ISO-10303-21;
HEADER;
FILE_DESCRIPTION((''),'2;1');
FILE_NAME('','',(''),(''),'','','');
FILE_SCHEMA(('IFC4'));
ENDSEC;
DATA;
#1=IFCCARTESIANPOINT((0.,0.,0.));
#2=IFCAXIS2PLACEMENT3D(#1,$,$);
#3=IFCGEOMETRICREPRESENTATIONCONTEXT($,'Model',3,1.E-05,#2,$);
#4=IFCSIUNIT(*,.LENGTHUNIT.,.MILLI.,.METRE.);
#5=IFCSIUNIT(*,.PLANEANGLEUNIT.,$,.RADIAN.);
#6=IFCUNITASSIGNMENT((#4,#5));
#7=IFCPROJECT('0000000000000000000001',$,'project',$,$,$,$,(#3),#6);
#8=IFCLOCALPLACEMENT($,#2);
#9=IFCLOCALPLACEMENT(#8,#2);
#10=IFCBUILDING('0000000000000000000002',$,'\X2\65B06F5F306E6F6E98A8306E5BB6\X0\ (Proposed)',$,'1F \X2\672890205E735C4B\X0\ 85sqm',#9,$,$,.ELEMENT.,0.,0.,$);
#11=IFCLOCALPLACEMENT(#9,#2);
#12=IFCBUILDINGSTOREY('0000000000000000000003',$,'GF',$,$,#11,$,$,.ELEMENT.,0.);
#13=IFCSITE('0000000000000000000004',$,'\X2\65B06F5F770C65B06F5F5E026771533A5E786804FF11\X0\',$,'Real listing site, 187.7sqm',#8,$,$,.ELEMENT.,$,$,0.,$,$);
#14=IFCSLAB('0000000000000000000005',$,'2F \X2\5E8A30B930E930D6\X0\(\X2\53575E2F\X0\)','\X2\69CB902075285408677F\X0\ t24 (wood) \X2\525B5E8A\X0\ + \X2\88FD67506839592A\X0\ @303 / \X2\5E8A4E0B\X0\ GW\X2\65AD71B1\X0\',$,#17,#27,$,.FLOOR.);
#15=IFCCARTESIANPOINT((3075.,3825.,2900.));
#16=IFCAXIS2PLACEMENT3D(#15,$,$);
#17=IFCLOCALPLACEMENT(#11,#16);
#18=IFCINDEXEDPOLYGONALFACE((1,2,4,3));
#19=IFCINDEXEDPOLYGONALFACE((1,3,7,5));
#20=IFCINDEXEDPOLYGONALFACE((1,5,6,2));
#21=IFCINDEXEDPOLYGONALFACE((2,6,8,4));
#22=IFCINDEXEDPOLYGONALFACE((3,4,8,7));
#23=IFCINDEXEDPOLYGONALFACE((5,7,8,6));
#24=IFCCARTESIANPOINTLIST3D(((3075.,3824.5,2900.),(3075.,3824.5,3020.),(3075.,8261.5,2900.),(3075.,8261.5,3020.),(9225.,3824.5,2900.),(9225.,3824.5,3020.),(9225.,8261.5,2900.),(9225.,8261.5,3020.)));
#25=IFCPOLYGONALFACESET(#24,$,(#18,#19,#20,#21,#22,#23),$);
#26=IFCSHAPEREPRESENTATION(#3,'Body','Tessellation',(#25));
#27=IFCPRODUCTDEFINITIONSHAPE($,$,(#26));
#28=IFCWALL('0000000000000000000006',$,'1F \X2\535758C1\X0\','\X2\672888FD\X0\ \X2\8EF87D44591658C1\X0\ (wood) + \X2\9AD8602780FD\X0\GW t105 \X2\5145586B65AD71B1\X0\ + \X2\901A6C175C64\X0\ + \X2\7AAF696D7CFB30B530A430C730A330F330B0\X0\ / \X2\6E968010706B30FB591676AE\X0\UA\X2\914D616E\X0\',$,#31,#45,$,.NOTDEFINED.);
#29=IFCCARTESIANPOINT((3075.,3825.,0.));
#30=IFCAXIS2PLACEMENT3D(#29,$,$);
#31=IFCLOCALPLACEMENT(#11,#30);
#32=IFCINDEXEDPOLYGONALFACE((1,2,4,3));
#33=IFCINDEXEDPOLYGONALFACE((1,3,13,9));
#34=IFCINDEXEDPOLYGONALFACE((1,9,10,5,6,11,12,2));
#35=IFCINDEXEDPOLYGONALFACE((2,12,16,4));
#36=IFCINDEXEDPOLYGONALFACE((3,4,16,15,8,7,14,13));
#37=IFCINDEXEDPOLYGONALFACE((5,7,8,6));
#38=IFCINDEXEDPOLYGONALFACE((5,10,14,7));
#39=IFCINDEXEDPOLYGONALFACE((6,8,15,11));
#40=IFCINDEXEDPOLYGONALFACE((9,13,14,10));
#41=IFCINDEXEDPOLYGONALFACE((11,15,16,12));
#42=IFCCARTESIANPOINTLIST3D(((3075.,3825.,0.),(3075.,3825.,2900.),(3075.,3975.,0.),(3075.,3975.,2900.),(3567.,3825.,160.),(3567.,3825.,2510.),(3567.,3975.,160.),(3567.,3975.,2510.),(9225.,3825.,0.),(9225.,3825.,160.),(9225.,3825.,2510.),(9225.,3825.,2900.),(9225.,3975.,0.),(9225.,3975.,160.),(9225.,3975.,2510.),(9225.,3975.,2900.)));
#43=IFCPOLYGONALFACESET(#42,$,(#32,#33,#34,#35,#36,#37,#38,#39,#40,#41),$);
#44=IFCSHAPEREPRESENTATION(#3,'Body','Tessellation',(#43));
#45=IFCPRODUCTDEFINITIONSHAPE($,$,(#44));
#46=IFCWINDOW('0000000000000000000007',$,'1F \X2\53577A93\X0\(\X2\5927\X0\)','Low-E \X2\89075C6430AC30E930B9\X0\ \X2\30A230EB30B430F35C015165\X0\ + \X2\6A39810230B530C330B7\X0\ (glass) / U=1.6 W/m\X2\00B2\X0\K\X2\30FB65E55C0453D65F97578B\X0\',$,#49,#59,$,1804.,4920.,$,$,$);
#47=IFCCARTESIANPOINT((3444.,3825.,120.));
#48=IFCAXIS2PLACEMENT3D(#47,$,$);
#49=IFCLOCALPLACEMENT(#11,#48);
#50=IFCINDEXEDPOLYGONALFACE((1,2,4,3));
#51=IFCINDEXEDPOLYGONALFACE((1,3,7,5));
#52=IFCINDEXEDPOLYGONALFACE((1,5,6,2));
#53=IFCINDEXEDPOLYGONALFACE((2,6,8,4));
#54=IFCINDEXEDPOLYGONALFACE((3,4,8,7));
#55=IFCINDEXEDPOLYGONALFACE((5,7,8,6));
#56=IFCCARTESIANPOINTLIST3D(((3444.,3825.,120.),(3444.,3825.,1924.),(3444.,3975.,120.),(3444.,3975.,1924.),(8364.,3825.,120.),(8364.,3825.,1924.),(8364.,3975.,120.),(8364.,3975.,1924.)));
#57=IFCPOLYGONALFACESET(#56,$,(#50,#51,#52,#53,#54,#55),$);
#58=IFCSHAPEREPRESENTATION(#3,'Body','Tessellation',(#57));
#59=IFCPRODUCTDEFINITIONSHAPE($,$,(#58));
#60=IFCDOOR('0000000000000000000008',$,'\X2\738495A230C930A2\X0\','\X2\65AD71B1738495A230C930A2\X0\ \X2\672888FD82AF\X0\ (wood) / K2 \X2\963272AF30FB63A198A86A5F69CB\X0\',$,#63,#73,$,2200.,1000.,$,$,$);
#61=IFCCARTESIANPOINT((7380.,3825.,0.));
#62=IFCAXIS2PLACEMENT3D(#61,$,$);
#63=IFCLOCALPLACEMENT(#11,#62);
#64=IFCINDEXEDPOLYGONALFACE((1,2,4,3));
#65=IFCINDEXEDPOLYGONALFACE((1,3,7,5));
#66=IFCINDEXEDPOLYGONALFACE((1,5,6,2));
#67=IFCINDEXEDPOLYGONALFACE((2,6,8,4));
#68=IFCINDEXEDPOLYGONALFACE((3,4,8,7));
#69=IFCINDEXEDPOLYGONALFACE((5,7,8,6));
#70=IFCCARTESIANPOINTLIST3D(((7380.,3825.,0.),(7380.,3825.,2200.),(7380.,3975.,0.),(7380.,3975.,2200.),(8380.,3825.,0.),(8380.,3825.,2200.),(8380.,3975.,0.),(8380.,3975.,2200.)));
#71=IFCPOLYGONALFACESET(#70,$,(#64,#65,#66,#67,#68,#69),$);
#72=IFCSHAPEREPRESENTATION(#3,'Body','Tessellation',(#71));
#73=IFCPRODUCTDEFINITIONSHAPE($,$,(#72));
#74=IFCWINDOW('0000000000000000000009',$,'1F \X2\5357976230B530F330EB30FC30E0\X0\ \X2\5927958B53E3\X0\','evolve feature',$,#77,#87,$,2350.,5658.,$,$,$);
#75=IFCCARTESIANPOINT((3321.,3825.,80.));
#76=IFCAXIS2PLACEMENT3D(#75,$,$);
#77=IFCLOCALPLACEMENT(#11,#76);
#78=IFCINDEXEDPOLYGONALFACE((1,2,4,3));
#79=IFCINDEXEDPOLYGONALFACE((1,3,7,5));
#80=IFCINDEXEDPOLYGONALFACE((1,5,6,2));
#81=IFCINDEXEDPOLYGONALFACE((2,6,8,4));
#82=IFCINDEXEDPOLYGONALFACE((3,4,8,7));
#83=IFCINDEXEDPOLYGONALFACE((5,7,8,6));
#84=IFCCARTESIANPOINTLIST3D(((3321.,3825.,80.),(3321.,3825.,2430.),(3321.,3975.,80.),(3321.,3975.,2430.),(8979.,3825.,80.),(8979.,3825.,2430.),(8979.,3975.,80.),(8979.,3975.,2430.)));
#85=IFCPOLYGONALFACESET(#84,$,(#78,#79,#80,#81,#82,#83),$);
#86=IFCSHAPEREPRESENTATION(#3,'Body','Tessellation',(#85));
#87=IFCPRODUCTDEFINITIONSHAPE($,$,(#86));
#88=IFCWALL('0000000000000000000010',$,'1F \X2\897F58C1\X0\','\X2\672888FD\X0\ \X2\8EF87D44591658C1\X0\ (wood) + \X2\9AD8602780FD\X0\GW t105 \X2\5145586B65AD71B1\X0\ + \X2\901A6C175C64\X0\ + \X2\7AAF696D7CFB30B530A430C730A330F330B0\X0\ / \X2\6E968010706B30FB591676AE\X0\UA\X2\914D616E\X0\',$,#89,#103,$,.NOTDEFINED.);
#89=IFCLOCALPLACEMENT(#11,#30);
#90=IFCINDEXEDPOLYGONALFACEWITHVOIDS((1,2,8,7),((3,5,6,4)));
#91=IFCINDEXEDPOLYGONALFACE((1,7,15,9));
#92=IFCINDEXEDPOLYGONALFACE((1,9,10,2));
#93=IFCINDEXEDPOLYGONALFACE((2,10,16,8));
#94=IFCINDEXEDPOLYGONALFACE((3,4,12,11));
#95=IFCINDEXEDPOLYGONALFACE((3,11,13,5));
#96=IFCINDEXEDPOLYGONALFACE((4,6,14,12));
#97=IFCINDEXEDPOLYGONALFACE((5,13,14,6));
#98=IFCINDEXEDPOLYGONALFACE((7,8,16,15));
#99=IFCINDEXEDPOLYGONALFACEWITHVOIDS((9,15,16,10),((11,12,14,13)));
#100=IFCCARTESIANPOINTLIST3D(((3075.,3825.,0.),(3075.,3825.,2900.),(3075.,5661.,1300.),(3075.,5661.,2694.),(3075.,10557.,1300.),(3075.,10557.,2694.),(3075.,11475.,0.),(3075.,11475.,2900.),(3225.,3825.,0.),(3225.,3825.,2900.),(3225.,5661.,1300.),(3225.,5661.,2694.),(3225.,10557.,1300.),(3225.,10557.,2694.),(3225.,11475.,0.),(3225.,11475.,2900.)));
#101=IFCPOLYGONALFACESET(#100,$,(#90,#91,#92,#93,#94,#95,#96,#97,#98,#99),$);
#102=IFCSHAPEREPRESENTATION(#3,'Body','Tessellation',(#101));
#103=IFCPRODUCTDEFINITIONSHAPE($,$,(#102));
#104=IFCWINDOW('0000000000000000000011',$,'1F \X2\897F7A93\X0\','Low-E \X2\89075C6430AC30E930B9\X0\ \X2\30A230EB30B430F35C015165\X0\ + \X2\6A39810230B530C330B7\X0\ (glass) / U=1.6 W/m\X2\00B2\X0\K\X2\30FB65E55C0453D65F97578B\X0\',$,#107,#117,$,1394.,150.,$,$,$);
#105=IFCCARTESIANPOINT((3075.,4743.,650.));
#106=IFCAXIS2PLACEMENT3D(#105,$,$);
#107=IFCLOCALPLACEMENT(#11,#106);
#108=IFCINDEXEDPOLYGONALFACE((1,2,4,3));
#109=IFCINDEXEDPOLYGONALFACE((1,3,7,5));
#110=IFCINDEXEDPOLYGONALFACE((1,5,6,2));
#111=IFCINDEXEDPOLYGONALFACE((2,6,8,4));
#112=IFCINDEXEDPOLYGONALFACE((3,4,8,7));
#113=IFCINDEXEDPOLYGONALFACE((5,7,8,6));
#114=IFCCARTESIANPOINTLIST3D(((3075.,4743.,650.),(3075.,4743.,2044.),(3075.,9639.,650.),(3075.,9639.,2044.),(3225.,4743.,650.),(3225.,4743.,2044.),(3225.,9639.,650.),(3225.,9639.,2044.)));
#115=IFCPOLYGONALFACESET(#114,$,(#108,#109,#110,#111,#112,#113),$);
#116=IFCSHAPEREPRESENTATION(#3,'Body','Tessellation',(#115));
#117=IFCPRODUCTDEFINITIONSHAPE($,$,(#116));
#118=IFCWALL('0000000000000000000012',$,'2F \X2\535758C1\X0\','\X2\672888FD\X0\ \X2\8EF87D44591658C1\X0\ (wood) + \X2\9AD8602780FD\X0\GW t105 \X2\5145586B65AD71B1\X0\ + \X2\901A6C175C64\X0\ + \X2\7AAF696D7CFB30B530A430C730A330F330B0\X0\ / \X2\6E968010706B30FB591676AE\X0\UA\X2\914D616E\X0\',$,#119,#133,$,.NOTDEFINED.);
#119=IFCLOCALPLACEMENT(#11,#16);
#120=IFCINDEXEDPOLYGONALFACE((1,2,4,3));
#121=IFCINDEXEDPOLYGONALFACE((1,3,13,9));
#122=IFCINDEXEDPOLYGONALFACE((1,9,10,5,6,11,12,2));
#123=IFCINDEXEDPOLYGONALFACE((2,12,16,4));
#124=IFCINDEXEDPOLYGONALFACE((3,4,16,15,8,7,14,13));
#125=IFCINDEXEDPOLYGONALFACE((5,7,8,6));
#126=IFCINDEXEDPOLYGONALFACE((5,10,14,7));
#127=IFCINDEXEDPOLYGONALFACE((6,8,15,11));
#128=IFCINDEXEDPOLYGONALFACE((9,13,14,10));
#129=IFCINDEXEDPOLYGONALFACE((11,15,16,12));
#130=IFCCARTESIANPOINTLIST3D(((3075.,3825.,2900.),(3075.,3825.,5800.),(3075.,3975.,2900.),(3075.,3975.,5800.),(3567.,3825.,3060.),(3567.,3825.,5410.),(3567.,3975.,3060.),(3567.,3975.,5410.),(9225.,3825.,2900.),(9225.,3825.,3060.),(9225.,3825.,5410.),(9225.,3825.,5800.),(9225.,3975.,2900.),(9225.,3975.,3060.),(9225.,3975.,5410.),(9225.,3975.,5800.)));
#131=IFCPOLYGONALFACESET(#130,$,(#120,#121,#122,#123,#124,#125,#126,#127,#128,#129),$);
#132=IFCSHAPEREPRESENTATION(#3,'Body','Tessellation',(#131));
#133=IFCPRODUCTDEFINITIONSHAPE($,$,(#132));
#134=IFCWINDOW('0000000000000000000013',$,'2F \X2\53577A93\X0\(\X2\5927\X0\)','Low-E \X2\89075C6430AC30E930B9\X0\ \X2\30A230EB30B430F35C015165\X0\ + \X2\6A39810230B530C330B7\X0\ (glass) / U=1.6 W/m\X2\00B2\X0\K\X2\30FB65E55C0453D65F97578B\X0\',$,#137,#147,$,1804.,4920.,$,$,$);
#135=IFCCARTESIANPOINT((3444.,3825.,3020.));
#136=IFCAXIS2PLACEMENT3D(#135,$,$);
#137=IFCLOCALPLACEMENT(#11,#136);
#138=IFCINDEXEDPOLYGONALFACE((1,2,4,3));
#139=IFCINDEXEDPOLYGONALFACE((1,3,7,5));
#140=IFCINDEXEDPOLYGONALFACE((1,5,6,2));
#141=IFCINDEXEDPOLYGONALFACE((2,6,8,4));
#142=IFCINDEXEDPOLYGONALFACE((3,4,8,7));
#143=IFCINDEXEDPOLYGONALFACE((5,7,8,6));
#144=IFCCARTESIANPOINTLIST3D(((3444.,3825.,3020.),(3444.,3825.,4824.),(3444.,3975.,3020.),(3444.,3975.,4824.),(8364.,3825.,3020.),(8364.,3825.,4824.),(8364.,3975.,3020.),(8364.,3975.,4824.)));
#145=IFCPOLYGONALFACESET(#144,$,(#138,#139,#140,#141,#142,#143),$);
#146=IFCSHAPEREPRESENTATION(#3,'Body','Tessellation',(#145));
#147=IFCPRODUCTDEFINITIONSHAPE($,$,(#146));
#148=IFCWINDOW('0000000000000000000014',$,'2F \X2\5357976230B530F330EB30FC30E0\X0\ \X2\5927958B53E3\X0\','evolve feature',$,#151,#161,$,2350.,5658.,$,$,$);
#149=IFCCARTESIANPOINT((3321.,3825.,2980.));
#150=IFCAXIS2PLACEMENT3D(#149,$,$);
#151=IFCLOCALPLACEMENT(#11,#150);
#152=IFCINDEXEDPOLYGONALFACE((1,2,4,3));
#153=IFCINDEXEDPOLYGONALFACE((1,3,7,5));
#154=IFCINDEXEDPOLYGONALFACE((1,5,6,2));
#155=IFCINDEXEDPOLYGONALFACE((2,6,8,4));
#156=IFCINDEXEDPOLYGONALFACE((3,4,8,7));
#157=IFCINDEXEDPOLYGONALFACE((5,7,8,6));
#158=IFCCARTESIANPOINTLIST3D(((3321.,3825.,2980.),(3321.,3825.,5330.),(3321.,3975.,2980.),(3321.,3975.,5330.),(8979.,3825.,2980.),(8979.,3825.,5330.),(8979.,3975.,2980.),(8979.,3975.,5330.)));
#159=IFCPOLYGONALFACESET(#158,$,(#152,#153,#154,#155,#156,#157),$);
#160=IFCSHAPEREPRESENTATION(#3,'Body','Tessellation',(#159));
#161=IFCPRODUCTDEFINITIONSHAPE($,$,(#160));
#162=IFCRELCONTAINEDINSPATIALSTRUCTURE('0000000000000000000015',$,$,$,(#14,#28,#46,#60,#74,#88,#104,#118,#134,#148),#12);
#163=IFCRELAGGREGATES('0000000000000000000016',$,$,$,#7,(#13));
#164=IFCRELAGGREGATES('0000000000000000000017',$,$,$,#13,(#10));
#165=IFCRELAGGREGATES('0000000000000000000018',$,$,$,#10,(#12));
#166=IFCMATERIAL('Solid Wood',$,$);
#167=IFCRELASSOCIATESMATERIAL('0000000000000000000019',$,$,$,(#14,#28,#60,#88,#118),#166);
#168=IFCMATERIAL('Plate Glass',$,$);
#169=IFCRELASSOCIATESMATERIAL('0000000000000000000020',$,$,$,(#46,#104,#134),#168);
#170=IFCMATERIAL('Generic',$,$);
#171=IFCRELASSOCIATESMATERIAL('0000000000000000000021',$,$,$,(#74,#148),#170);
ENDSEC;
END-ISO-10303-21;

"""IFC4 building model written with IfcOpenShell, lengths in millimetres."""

from ifc_helpers import new_model, si_unit, frame, frame_2d, origin, place, context, project, spatial, rectangle, extrude, material, element, fill, save


model = new_model("IFC4")

# Units and contexts
model_context = context("Model", 3, precision=1e-05, world=origin())
ifc_project = project(units=[si_unit("LENGTHUNIT", "METRE", prefix="MILLI"), si_unit("PLANEANGLEUNIT", "RADIAN")], contexts=[model_context])

# Site, building, storey
site_placement = place(None, origin())
site = spatial("IfcSite", under=ifc_project, at=site_placement, Name="新潟県新潟市東区幸栄１", ObjectType="Real listing site, 187.7sqm", CompositionType="ELEMENT", RefElevation=0.0)
building_placement = place(site_placement, origin())
building = spatial("IfcBuilding", under=site, at=building_placement, Name="新潟の潮風の家 (Proposed)", ObjectType="1F 木造平屋 85sqm", CompositionType="ELEMENT", ElevationOfRefHeight=0.0, ElevationOfTerrain=0.0)
storey_placement = place(building_placement, origin())
storey = spatial("IfcBuildingStorey", under=building, at=storey_placement, Name="GF", CompositionType="ELEMENT", Elevation=0.0)

# Slab
ifc_material_1 = material(Name="Solid Wood")
slab_1_placement = place(storey_placement, frame((3075.0, 3825.0, 2900.0)))
element("IfcSlab", 1, at=slab_1_placement, inside=storey, material=ifc_material_1, Name="2F 床スラブ(南帯)", Description="構造用合板 t24 (wood) 剛床 + 製材根太 @303 / 床下 GW断熱", PredefinedType="FLOOR", context=model_context, shape_type="SweptSolid", body=[
    extrude(rectangle(XDim=6150.0, YDim=4437.0, at=frame_2d((3075.0, 2218.0))), frame((3075.0, 3825.0, 2900.0)), (0.0, 0.0, 1.0), 120.0),
])
ifc_material_2 = material(Name="Generic")

# Wall, openings, windows, door
wall_1_placement = place(storey_placement, frame((3075.0, 3825.0, 0.0)))
wall_1 = element("IfcWall", 2, at=wall_1_placement, inside=storey, material=ifc_material_1, Name="1F 南壁", Description="木製 軸組外壁 (wood) + 高性能GW t105 充填断熱 + 通気層 + 窯業系サイディング / 準耐火・外皮UA配慮", PredefinedType="NOTDEFINED", context=model_context, shape_type="SweptSolid", body=[
    extrude(rectangle(XDim=6150.0, YDim=150.0, at=frame_2d((3075.0, 75.0))), frame((3075.0, 3825.0, 0.0)), (0.0, 0.0, 1.0), 2900.0),
])
opening_1_placement = place(storey_placement, frame((3444.0, 3825.0, 120.0)))
opening_1 = element("IfcOpeningElement", 3, at=opening_1_placement, cuts=wall_1, PredefinedType="NOTDEFINED", context=model_context, shape_type="SweptSolid", body=[
    extrude(rectangle(XDim=4920.0, YDim=150.0, at=frame_2d((2460.0, 75.0))), frame((3444.0, 3825.0, 120.0)), (0.0, 0.0, 1.0), 1804.0),
])
opening_2_placement = place(storey_placement, frame((7380.0, 3825.0, 0.0)))
opening_2 = element("IfcOpeningElement", 4, at=opening_2_placement, cuts=wall_1, PredefinedType="NOTDEFINED", context=model_context, shape_type="SweptSolid", body=[
    extrude(rectangle(XDim=1000.0, YDim=150.0, at=frame_2d((500.0, 75.0))), frame((7380.0, 3825.0, 0.0)), (0.0, 0.0, 1.0), 2200.0),
])
opening_3_placement = place(storey_placement, frame((3321.0, 3825.0, 80.0)))
opening_3 = element("IfcOpeningElement", 5, at=opening_3_placement, cuts=wall_1, PredefinedType="NOTDEFINED", context=model_context, shape_type="SweptSolid", body=[
    extrude(rectangle(XDim=5658.0, YDim=150.0, at=frame_2d((2829.0, 75.0))), frame((3321.0, 3825.0, 80.0)), (0.0, 0.0, 1.0), 2350.0),
])
ifc_material_3 = material(Name="Plate Glass")
window_1_placement = place(storey_placement, frame((3444.0, 3825.0, 120.0)))
window_1 = element("IfcWindow", 6, at=window_1_placement, inside=storey, material=ifc_material_3, Name="1F 南窓(大)", Description="Low-E 複層ガラス アルゴン封入 + 樹脂サッシ (glass) / U=1.6 W/m²K・日射取得型", OverallHeight=1804.0, OverallWidth=4920.0, context=model_context, shape_type="SweptSolid", body=[
    extrude(rectangle(XDim=4920.0, YDim=150.0, at=frame_2d((2460.0, 75.0))), frame((3444.0, 3825.0, 120.0)), (0.0, 0.0, 1.0), 1804.0),
])
fill(opening_1, window_1)
door_placement = place(storey_placement, frame((7380.0, 3825.0, 0.0)))
door = element("IfcDoor", 7, at=door_placement, inside=storey, material=ifc_material_1, Name="玄関ドア", Description="断熱玄関ドア 木製芯 (wood) / K2 防犯・採風機構", OverallHeight=2200.0, OverallWidth=1000.0, context=model_context, shape_type="SweptSolid", body=[
    extrude(rectangle(XDim=1000.0, YDim=150.0, at=frame_2d((500.0, 75.0))), frame((7380.0, 3825.0, 0.0)), (0.0, 0.0, 1.0), 2200.0),
])
fill(opening_2, door)
window_2_placement = place(storey_placement, frame((3321.0, 3825.0, 80.0)))
window_2 = element("IfcWindow", 8, at=window_2_placement, inside=storey, material=ifc_material_2, Name="1F 南面サンルーム 大開口", Description="evolve feature", OverallHeight=2350.0, OverallWidth=5658.0, context=model_context, shape_type="SweptSolid", body=[
    extrude(rectangle(XDim=5658.0, YDim=150.0, at=frame_2d((2829.0, 75.0))), frame((3321.0, 3825.0, 80.0)), (0.0, 0.0, 1.0), 2350.0),
])
fill(opening_3, window_2)

# Wall, opening, window
wall_2_placement = place(storey_placement, frame((3075.0, 3825.0, 0.0)))
wall_2 = element("IfcWall", 9, at=wall_2_placement, inside=storey, material=ifc_material_1, Name="1F 西壁", Description="木製 軸組外壁 (wood) + 高性能GW t105 充填断熱 + 通気層 + 窯業系サイディング / 準耐火・外皮UA配慮", PredefinedType="NOTDEFINED", context=model_context, shape_type="SweptSolid", body=[
    extrude(rectangle(XDim=150.0, YDim=7650.0, at=frame_2d((75.0, 3825.0))), frame((3075.0, 3825.0, 0.0)), (0.0, 0.0, 1.0), 2900.0),
])
opening_4_placement = place(storey_placement, frame((3075.0, 4743.0, 650.0)))
opening_4 = element("IfcOpeningElement", 10, at=opening_4_placement, cuts=wall_2, PredefinedType="NOTDEFINED", context=model_context, shape_type="SweptSolid", body=[
    extrude(rectangle(XDim=150.0, YDim=4896.0, at=frame_2d((75.0, 2448.0))), frame((3075.0, 4743.0, 650.0)), (0.0, 0.0, 1.0), 1394.0),
])
window_3_placement = place(storey_placement, frame((3075.0, 4743.0, 650.0)))
window_3 = element("IfcWindow", 11, at=window_3_placement, inside=storey, material=ifc_material_3, Name="1F 西窓", Description="Low-E 複層ガラス アルゴン封入 + 樹脂サッシ (glass) / U=1.6 W/m²K・日射取得型", OverallHeight=1394.0, OverallWidth=150.0, context=model_context, shape_type="SweptSolid", body=[
    extrude(rectangle(XDim=150.0, YDim=4896.0, at=frame_2d((75.0, 2448.0))), frame((3075.0, 4743.0, 650.0)), (0.0, 0.0, 1.0), 1394.0),
])
fill(opening_4, window_3)

# Wall, openings, windows
wall_3_placement = place(storey_placement, frame((3075.0, 3825.0, 2900.0)))
wall_3 = element("IfcWall", 12, at=wall_3_placement, inside=storey, material=ifc_material_1, Name="2F 南壁", Description="木製 軸組外壁 (wood) + 高性能GW t105 充填断熱 + 通気層 + 窯業系サイディング / 準耐火・外皮UA配慮", PredefinedType="NOTDEFINED", context=model_context, shape_type="SweptSolid", body=[
    extrude(rectangle(XDim=6150.0, YDim=150.0, at=frame_2d((3075.0, 75.0))), frame((3075.0, 3825.0, 2900.0)), (0.0, 0.0, 1.0), 2900.0),
])
opening_5_placement = place(storey_placement, frame((3444.0, 3825.0, 3020.0)))
opening_5 = element("IfcOpeningElement", 13, at=opening_5_placement, cuts=wall_3, PredefinedType="NOTDEFINED", context=model_context, shape_type="SweptSolid", body=[
    extrude(rectangle(XDim=4920.0, YDim=150.0, at=frame_2d((2460.0, 75.0))), frame((3444.0, 3825.0, 3020.0)), (0.0, 0.0, 1.0), 1804.0),
])
opening_6_placement = place(storey_placement, frame((3321.0, 3825.0, 2980.0)))
opening_6 = element("IfcOpeningElement", 14, at=opening_6_placement, cuts=wall_3, PredefinedType="NOTDEFINED", context=model_context, shape_type="SweptSolid", body=[
    extrude(rectangle(XDim=5658.0, YDim=150.0, at=frame_2d((2829.0, 75.0))), frame((3321.0, 3825.0, 2980.0)), (0.0, 0.0, 1.0), 2350.0),
])
window_4_placement = place(storey_placement, frame((3444.0, 3825.0, 3020.0)))
window_4 = element("IfcWindow", 15, at=window_4_placement, inside=storey, material=ifc_material_3, Name="2F 南窓(大)", Description="Low-E 複層ガラス アルゴン封入 + 樹脂サッシ (glass) / U=1.6 W/m²K・日射取得型", OverallHeight=1804.0, OverallWidth=4920.0, context=model_context, shape_type="SweptSolid", body=[
    extrude(rectangle(XDim=4920.0, YDim=150.0, at=frame_2d((2460.0, 75.0))), frame((3444.0, 3825.0, 3020.0)), (0.0, 0.0, 1.0), 1804.0),
])
fill(opening_5, window_4)
window_5_placement = place(storey_placement, frame((3321.0, 3825.0, 2980.0)))
window_5 = element("IfcWindow", 16, at=window_5_placement, inside=storey, material=ifc_material_2, Name="2F 南面サンルーム 大開口", Description="evolve feature", OverallHeight=2350.0, OverallWidth=5658.0, context=model_context, shape_type="SweptSolid", body=[
    extrude(rectangle(XDim=5658.0, YDim=150.0, at=frame_2d((2829.0, 75.0))), frame((3321.0, 3825.0, 2980.0)), (0.0, 0.0, 1.0), 2350.0),
])
fill(opening_6, window_5)

save(model, "model.ifc")
